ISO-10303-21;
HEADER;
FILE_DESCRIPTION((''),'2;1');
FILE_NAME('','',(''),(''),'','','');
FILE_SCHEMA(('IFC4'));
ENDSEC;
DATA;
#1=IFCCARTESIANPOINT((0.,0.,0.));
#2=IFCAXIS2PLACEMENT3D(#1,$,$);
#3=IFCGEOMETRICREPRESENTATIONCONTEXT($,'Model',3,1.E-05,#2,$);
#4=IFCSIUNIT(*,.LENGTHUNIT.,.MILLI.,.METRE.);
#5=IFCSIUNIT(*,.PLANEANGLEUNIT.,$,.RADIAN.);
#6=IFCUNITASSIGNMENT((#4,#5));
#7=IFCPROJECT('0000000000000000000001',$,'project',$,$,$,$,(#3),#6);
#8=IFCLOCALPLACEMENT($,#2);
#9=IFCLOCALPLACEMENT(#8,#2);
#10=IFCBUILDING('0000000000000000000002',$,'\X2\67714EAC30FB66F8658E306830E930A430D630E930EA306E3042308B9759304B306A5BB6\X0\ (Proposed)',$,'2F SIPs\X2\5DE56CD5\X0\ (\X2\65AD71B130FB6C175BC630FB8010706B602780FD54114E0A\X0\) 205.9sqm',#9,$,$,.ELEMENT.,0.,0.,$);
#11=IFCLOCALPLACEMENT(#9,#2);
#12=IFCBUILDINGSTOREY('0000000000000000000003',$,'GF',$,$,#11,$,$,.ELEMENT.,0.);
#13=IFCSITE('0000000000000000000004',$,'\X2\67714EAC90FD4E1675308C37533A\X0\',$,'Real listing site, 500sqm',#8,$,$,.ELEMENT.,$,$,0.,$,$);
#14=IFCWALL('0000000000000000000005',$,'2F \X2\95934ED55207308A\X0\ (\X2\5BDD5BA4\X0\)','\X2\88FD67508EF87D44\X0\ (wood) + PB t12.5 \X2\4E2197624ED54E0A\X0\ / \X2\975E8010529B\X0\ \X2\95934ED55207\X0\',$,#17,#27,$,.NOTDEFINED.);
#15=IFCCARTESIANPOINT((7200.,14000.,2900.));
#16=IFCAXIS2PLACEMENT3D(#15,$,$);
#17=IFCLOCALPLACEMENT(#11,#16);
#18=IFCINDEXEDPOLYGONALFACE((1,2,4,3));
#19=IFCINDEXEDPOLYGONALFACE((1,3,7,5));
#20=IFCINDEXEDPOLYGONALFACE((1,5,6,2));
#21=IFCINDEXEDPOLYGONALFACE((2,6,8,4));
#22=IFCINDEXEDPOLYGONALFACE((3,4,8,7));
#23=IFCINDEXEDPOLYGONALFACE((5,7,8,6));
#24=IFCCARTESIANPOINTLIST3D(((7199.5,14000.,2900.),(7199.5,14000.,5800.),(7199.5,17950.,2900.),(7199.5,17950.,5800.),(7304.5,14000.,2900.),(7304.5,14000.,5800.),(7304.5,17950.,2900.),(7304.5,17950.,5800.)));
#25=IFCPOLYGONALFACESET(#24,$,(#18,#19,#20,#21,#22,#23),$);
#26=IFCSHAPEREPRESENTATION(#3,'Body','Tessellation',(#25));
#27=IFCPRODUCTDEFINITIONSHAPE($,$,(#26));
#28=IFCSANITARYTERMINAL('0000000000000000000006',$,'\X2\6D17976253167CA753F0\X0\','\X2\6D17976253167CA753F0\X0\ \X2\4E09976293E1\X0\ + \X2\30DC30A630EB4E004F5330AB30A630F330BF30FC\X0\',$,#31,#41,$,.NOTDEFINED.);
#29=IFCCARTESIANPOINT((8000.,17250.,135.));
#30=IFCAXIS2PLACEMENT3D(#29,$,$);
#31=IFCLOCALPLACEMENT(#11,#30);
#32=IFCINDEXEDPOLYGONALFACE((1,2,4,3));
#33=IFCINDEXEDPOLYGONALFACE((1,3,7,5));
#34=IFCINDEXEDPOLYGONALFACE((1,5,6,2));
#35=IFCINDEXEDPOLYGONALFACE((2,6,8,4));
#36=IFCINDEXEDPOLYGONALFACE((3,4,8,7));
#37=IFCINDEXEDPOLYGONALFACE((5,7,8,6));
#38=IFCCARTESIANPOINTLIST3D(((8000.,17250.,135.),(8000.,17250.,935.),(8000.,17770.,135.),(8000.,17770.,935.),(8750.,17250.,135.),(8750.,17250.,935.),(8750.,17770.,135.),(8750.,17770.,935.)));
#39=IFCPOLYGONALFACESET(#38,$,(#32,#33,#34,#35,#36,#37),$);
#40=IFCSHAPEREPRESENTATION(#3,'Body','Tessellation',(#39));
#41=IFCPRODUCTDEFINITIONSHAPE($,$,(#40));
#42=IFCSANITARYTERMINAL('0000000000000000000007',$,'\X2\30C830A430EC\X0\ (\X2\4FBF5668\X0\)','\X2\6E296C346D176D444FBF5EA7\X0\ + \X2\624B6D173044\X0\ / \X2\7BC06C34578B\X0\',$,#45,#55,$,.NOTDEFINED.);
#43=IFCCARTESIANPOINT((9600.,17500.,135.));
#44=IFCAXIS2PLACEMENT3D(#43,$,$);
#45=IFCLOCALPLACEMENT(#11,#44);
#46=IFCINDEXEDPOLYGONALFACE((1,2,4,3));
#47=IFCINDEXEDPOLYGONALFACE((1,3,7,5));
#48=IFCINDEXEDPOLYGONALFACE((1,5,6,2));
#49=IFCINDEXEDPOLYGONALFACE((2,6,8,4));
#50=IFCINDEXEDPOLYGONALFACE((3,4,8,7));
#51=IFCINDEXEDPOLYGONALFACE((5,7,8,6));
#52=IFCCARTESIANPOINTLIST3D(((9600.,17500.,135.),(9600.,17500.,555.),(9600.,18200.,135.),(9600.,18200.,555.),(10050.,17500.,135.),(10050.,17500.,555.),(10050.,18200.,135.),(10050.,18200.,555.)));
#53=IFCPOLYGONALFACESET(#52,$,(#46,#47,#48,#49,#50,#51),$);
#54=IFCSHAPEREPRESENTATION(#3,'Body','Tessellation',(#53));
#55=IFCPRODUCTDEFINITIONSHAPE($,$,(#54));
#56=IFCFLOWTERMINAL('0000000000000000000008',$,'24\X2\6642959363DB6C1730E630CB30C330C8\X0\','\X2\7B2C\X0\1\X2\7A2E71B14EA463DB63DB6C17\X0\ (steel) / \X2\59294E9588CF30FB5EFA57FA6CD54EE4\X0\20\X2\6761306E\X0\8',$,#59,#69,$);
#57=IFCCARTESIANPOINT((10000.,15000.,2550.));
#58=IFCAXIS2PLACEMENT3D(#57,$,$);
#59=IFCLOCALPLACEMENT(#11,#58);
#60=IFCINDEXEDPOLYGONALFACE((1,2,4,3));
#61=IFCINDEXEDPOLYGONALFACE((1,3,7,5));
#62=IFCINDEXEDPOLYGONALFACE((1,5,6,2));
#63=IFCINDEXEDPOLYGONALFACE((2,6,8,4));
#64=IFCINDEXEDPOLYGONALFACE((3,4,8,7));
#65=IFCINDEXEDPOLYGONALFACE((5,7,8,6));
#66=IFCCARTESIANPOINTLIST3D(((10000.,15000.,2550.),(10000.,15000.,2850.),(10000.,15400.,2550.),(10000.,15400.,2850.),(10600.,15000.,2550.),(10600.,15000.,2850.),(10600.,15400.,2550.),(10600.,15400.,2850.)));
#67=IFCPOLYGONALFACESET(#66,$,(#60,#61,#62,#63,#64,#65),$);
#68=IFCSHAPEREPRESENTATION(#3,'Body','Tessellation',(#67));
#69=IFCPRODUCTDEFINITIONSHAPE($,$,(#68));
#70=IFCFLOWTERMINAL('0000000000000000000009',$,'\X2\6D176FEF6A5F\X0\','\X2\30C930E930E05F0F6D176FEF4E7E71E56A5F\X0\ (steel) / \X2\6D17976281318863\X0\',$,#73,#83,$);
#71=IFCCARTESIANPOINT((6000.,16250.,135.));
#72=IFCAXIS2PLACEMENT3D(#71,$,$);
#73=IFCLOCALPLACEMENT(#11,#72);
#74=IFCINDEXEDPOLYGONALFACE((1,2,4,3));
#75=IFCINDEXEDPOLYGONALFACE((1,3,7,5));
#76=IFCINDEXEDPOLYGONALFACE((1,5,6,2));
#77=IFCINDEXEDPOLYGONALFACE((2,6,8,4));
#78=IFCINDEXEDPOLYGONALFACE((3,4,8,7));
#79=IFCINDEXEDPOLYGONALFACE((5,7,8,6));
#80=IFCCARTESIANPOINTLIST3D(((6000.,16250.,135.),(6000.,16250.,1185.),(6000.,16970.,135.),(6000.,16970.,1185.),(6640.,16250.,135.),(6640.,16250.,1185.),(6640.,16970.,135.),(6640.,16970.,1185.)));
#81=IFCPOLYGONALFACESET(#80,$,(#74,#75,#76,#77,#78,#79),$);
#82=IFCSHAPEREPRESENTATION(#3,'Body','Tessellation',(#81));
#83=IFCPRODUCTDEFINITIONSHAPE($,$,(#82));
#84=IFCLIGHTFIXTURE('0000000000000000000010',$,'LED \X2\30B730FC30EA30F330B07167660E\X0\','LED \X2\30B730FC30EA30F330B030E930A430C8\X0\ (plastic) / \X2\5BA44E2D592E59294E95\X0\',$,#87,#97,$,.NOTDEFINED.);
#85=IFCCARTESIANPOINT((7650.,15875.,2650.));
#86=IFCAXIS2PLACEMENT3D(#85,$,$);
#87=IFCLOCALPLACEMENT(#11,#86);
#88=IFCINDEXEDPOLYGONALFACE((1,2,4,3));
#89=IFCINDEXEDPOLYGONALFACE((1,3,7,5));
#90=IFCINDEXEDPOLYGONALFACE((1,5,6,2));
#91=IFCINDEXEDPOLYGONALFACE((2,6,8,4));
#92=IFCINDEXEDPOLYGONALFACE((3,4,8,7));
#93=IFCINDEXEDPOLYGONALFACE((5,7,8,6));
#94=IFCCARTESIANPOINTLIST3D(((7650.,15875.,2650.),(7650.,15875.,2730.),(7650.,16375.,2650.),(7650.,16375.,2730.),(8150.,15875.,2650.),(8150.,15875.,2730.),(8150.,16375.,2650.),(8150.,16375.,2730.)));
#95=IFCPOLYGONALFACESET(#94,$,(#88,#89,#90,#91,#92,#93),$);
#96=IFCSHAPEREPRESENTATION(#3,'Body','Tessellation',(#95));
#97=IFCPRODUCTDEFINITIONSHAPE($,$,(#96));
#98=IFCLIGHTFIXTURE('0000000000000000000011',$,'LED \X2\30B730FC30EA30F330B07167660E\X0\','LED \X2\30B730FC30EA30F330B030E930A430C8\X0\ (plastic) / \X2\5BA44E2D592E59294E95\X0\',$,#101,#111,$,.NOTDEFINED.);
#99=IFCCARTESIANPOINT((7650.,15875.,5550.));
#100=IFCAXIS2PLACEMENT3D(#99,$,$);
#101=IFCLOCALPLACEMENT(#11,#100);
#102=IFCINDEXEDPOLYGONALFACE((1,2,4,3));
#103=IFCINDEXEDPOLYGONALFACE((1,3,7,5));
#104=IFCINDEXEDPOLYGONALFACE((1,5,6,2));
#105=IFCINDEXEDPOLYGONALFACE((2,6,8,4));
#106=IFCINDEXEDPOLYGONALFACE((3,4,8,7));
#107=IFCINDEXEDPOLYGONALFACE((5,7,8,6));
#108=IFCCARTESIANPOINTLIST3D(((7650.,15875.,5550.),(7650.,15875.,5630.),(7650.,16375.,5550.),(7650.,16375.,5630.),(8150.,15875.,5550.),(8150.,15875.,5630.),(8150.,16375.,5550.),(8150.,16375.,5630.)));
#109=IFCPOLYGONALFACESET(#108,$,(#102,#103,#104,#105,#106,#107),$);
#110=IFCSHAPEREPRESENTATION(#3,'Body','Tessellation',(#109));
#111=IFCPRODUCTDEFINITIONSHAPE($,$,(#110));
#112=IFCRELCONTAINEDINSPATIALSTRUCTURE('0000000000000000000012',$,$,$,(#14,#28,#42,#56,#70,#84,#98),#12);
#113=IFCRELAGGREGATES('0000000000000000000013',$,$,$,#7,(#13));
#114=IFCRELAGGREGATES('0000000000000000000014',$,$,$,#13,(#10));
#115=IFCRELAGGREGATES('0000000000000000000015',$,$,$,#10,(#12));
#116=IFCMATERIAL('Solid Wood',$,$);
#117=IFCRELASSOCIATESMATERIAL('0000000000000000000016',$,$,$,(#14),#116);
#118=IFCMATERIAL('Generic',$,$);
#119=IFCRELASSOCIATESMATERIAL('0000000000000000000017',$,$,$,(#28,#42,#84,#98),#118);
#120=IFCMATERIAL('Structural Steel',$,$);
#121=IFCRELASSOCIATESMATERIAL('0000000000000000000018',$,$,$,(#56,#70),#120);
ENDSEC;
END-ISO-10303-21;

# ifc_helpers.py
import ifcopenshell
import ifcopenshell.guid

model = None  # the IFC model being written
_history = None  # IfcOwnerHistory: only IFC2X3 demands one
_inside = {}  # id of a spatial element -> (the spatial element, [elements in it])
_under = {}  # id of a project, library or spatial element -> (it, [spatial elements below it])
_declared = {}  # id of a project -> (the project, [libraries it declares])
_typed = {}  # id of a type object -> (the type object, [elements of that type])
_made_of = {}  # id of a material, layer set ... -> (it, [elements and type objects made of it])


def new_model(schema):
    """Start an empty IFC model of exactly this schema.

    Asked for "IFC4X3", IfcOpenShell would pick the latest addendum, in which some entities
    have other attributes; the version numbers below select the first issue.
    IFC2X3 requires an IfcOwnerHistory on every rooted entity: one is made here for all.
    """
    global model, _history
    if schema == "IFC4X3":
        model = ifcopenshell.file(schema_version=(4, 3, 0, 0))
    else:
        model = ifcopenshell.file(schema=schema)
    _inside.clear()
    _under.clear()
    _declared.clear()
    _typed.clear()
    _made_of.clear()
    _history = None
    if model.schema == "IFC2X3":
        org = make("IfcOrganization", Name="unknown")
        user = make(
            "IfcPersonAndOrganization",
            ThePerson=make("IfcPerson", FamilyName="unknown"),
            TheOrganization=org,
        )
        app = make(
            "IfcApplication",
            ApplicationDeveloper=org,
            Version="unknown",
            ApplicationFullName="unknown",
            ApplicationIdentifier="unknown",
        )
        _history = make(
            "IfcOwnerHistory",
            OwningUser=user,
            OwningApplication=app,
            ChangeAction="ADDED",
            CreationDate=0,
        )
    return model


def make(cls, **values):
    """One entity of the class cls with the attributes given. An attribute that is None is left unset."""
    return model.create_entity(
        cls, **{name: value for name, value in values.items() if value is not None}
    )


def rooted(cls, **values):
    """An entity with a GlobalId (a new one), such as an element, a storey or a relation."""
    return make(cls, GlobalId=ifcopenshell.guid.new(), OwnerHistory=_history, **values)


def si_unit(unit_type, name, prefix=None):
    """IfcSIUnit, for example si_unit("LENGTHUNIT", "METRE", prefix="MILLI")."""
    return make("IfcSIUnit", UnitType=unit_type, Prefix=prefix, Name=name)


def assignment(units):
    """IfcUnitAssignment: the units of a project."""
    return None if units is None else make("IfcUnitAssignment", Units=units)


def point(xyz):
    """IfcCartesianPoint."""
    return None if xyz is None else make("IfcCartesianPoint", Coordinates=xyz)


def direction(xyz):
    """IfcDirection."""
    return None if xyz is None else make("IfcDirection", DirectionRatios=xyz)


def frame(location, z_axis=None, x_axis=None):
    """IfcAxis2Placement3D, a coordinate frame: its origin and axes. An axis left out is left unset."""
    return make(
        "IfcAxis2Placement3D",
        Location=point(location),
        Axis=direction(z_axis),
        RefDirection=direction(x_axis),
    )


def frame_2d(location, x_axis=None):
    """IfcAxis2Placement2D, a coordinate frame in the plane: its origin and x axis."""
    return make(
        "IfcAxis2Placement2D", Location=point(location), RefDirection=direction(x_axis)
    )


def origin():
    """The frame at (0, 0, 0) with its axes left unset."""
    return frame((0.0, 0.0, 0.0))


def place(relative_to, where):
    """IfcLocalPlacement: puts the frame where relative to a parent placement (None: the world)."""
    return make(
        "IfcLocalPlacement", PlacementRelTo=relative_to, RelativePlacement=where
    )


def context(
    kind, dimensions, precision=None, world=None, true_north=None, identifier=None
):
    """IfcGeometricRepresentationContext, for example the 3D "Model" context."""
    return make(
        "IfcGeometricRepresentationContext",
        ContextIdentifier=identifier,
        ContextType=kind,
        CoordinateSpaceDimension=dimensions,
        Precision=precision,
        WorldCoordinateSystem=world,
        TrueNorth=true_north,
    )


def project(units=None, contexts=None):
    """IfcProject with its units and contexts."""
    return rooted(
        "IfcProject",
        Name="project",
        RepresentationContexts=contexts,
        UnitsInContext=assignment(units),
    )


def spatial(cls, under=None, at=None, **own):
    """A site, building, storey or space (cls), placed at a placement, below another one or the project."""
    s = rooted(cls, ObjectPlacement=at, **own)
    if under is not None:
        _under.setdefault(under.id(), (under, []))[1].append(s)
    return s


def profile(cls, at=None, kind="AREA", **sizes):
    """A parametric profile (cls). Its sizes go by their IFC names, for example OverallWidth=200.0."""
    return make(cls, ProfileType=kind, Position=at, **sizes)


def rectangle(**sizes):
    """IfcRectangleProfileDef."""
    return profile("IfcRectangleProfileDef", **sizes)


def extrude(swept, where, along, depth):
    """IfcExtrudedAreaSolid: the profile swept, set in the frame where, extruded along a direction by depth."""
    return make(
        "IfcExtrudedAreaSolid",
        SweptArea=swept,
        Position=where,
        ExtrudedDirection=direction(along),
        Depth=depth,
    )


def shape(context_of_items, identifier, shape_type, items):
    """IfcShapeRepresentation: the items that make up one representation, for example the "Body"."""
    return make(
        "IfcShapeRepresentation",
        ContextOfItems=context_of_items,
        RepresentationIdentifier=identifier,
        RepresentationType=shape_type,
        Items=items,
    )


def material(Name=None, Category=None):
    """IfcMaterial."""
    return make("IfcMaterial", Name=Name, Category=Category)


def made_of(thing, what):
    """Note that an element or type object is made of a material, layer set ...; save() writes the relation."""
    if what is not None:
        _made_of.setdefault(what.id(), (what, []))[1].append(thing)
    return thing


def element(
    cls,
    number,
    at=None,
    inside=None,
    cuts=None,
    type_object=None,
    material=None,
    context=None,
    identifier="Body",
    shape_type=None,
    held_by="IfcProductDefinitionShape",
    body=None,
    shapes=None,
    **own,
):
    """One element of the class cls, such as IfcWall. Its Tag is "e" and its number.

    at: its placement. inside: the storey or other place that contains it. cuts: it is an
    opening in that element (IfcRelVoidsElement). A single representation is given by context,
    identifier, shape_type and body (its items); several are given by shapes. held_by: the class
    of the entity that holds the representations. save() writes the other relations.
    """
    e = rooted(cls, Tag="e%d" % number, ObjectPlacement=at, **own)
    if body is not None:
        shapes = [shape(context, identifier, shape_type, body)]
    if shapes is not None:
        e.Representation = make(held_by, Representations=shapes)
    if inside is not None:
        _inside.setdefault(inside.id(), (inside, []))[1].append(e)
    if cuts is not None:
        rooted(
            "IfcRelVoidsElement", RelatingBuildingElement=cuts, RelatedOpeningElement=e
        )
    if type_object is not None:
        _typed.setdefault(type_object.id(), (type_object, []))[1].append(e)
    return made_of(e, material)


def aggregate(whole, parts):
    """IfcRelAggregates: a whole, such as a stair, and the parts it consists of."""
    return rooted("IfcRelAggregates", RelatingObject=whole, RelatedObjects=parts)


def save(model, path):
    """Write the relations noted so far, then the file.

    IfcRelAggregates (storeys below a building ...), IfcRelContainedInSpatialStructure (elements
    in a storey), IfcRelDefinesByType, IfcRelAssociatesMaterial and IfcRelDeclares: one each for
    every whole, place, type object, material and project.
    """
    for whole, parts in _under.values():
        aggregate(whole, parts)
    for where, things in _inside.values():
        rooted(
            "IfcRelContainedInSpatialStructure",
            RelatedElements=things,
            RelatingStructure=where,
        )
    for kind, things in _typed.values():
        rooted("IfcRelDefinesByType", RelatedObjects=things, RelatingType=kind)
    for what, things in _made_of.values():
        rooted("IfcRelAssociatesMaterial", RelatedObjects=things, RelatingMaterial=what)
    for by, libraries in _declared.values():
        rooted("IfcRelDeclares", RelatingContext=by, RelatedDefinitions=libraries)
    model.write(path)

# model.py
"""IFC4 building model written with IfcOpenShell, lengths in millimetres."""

from ifc_helpers import new_model, si_unit, frame, frame_2d, origin, place, context, project, spatial, rectangle, extrude, material, element, save


model = new_model("IFC4")

# Units and contexts
model_context = context("Model", 3, precision=1e-05, world=origin())
ifc_project = project(units=[si_unit("LENGTHUNIT", "METRE", prefix="MILLI"), si_unit("PLANEANGLEUNIT", "RADIAN")], contexts=[model_context])

# Site, building, storey
site_placement = place(None, origin())
site = spatial("IfcSite", under=ifc_project, at=site_placement, Name="東京都世田谷区", ObjectType="Real listing site, 500sqm", CompositionType="ELEMENT", RefElevation=0.0)
building_placement = place(site_placement, origin())
building = spatial("IfcBuilding", under=site, at=building_placement, Name="東京・書斎とライブラリのある静かな家 (Proposed)", ObjectType="2F SIPs工法 (断熱・気密・耐火性能向上) 205.9sqm", CompositionType="ELEMENT", ElevationOfRefHeight=0.0, ElevationOfTerrain=0.0)
storey_placement = place(building_placement, origin())
storey = spatial("IfcBuildingStorey", under=building, at=storey_placement, Name="GF", CompositionType="ELEMENT", Elevation=0.0)

# Shared definitions
ifc_material_1 = material(Name="Solid Wood")

# Wall
wall_1_placement = place(storey_placement, frame((7200.0, 14000.0, 2900.0)))
element("IfcWall", 1, at=wall_1_placement, inside=storey, material=ifc_material_1, Name="2F 間仕切り (寝室)", Description="製材軸組 (wood) + PB t12.5 両面仕上 / 非耐力 間仕切", PredefinedType="NOTDEFINED", context=model_context, shape_type="SweptSolid", body=[
    extrude(rectangle(XDim=105.0, YDim=3950.0, at=frame_2d((52.0, 1975.0))), frame((7200.0, 14000.0, 2900.0)), (0.0, 0.0, 1.0), 2900.0),
])

# Sanitary terminals
ifc_material_2 = material(Name="Generic")
sanitary_terminal_1_placement = place(storey_placement, frame((8000.0, 17250.0, 135.0)))
element("IfcSanitaryTerminal", 2, at=sanitary_terminal_1_placement, inside=storey, material=ifc_material_2, Name="洗面化粧台", Description="洗面化粧台 三面鏡 + ボウル一体カウンター", PredefinedType="NOTDEFINED", context=model_context, shape_type="SweptSolid", body=[
    extrude(rectangle(XDim=750.0, YDim=520.0, at=frame_2d((375.0, 260.0))), frame((8000.0, 17250.0, 135.0)), (0.0, 0.0, 1.0), 800.0),
])
sanitary_terminal_2_placement = place(storey_placement, frame((9600.0, 17500.0, 135.0)))
element("IfcSanitaryTerminal", 3, at=sanitary_terminal_2_placement, inside=storey, material=ifc_material_2, Name="トイレ (便器)", Description="温水洗浄便座 + 手洗い / 節水型", PredefinedType="NOTDEFINED", context=model_context, shape_type="SweptSolid", body=[
    extrude(rectangle(XDim=450.0, YDim=700.0, at=frame_2d((225.0, 350.0))), frame((9600.0, 17500.0, 135.0)), (0.0, 0.0, 1.0), 420.0),
])

# Flow terminals
ifc_material_3 = material(Name="Structural Steel")
flow_terminal_1_placement = place(storey_placement, frame((10000.0, 15000.0, 2550.0)))
element("IfcFlowTerminal", 4, at=flow_terminal_1_placement, inside=storey, material=ifc_material_3, Name="24時間換気ユニット", Description="第1種熱交換換気 (steel) / 天井裏・建基法令20条の8", context=model_context, shape_type="SweptSolid", body=[
    extrude(rectangle(XDim=600.0, YDim=400.0, at=frame_2d((300.0, 200.0))), frame((10000.0, 15000.0, 2550.0)), (0.0, 0.0, 1.0), 300.0),
])
flow_terminal_2_placement = place(storey_placement, frame((6000.0, 16250.0, 135.0)))
element("IfcFlowTerminal", 5, at=flow_terminal_2_placement, inside=storey, material=ifc_material_3, Name="洗濯機", Description="ドラム式洗濯乾燥機 (steel) / 洗面脱衣", context=model_context, shape_type="SweptSolid", body=[
    extrude(rectangle(XDim=640.0, YDim=720.0, at=frame_2d((320.0, 360.0))), frame((6000.0, 16250.0, 135.0)), (0.0, 0.0, 1.0), 1050.0),
])

# Light fixtures
light_fixture_1_placement = place(storey_placement, frame((7650.0, 15875.0, 2650.0)))
element("IfcLightFixture", 6, at=light_fixture_1_placement, inside=storey, material=ifc_material_2, Name="LED シーリング照明", Description="LED シーリングライト (plastic) / 室中央天井", PredefinedType="NOTDEFINED", context=model_context, shape_type="SweptSolid", body=[
    extrude(rectangle(XDim=500.0, YDim=500.0, at=frame_2d((250.0, 250.0))), frame((7650.0, 15875.0, 2650.0)), (0.0, 0.0, 1.0), 80.0),
])
light_fixture_2_placement = place(storey_placement, frame((7650.0, 15875.0, 5550.0)))
element("IfcLightFixture", 7, at=light_fixture_2_placement, inside=storey, material=ifc_material_2, Name="LED シーリング照明", Description="LED シーリングライト (plastic) / 室中央天井", PredefinedType="NOTDEFINED", context=model_context, shape_type="SweptSolid", body=[
    extrude(rectangle(XDim=500.0, YDim=500.0, at=frame_2d((250.0, 250.0))), frame((7650.0, 15875.0, 5550.0)), (0.0, 0.0, 1.0), 80.0),
])

save(model, "model.ifc")
